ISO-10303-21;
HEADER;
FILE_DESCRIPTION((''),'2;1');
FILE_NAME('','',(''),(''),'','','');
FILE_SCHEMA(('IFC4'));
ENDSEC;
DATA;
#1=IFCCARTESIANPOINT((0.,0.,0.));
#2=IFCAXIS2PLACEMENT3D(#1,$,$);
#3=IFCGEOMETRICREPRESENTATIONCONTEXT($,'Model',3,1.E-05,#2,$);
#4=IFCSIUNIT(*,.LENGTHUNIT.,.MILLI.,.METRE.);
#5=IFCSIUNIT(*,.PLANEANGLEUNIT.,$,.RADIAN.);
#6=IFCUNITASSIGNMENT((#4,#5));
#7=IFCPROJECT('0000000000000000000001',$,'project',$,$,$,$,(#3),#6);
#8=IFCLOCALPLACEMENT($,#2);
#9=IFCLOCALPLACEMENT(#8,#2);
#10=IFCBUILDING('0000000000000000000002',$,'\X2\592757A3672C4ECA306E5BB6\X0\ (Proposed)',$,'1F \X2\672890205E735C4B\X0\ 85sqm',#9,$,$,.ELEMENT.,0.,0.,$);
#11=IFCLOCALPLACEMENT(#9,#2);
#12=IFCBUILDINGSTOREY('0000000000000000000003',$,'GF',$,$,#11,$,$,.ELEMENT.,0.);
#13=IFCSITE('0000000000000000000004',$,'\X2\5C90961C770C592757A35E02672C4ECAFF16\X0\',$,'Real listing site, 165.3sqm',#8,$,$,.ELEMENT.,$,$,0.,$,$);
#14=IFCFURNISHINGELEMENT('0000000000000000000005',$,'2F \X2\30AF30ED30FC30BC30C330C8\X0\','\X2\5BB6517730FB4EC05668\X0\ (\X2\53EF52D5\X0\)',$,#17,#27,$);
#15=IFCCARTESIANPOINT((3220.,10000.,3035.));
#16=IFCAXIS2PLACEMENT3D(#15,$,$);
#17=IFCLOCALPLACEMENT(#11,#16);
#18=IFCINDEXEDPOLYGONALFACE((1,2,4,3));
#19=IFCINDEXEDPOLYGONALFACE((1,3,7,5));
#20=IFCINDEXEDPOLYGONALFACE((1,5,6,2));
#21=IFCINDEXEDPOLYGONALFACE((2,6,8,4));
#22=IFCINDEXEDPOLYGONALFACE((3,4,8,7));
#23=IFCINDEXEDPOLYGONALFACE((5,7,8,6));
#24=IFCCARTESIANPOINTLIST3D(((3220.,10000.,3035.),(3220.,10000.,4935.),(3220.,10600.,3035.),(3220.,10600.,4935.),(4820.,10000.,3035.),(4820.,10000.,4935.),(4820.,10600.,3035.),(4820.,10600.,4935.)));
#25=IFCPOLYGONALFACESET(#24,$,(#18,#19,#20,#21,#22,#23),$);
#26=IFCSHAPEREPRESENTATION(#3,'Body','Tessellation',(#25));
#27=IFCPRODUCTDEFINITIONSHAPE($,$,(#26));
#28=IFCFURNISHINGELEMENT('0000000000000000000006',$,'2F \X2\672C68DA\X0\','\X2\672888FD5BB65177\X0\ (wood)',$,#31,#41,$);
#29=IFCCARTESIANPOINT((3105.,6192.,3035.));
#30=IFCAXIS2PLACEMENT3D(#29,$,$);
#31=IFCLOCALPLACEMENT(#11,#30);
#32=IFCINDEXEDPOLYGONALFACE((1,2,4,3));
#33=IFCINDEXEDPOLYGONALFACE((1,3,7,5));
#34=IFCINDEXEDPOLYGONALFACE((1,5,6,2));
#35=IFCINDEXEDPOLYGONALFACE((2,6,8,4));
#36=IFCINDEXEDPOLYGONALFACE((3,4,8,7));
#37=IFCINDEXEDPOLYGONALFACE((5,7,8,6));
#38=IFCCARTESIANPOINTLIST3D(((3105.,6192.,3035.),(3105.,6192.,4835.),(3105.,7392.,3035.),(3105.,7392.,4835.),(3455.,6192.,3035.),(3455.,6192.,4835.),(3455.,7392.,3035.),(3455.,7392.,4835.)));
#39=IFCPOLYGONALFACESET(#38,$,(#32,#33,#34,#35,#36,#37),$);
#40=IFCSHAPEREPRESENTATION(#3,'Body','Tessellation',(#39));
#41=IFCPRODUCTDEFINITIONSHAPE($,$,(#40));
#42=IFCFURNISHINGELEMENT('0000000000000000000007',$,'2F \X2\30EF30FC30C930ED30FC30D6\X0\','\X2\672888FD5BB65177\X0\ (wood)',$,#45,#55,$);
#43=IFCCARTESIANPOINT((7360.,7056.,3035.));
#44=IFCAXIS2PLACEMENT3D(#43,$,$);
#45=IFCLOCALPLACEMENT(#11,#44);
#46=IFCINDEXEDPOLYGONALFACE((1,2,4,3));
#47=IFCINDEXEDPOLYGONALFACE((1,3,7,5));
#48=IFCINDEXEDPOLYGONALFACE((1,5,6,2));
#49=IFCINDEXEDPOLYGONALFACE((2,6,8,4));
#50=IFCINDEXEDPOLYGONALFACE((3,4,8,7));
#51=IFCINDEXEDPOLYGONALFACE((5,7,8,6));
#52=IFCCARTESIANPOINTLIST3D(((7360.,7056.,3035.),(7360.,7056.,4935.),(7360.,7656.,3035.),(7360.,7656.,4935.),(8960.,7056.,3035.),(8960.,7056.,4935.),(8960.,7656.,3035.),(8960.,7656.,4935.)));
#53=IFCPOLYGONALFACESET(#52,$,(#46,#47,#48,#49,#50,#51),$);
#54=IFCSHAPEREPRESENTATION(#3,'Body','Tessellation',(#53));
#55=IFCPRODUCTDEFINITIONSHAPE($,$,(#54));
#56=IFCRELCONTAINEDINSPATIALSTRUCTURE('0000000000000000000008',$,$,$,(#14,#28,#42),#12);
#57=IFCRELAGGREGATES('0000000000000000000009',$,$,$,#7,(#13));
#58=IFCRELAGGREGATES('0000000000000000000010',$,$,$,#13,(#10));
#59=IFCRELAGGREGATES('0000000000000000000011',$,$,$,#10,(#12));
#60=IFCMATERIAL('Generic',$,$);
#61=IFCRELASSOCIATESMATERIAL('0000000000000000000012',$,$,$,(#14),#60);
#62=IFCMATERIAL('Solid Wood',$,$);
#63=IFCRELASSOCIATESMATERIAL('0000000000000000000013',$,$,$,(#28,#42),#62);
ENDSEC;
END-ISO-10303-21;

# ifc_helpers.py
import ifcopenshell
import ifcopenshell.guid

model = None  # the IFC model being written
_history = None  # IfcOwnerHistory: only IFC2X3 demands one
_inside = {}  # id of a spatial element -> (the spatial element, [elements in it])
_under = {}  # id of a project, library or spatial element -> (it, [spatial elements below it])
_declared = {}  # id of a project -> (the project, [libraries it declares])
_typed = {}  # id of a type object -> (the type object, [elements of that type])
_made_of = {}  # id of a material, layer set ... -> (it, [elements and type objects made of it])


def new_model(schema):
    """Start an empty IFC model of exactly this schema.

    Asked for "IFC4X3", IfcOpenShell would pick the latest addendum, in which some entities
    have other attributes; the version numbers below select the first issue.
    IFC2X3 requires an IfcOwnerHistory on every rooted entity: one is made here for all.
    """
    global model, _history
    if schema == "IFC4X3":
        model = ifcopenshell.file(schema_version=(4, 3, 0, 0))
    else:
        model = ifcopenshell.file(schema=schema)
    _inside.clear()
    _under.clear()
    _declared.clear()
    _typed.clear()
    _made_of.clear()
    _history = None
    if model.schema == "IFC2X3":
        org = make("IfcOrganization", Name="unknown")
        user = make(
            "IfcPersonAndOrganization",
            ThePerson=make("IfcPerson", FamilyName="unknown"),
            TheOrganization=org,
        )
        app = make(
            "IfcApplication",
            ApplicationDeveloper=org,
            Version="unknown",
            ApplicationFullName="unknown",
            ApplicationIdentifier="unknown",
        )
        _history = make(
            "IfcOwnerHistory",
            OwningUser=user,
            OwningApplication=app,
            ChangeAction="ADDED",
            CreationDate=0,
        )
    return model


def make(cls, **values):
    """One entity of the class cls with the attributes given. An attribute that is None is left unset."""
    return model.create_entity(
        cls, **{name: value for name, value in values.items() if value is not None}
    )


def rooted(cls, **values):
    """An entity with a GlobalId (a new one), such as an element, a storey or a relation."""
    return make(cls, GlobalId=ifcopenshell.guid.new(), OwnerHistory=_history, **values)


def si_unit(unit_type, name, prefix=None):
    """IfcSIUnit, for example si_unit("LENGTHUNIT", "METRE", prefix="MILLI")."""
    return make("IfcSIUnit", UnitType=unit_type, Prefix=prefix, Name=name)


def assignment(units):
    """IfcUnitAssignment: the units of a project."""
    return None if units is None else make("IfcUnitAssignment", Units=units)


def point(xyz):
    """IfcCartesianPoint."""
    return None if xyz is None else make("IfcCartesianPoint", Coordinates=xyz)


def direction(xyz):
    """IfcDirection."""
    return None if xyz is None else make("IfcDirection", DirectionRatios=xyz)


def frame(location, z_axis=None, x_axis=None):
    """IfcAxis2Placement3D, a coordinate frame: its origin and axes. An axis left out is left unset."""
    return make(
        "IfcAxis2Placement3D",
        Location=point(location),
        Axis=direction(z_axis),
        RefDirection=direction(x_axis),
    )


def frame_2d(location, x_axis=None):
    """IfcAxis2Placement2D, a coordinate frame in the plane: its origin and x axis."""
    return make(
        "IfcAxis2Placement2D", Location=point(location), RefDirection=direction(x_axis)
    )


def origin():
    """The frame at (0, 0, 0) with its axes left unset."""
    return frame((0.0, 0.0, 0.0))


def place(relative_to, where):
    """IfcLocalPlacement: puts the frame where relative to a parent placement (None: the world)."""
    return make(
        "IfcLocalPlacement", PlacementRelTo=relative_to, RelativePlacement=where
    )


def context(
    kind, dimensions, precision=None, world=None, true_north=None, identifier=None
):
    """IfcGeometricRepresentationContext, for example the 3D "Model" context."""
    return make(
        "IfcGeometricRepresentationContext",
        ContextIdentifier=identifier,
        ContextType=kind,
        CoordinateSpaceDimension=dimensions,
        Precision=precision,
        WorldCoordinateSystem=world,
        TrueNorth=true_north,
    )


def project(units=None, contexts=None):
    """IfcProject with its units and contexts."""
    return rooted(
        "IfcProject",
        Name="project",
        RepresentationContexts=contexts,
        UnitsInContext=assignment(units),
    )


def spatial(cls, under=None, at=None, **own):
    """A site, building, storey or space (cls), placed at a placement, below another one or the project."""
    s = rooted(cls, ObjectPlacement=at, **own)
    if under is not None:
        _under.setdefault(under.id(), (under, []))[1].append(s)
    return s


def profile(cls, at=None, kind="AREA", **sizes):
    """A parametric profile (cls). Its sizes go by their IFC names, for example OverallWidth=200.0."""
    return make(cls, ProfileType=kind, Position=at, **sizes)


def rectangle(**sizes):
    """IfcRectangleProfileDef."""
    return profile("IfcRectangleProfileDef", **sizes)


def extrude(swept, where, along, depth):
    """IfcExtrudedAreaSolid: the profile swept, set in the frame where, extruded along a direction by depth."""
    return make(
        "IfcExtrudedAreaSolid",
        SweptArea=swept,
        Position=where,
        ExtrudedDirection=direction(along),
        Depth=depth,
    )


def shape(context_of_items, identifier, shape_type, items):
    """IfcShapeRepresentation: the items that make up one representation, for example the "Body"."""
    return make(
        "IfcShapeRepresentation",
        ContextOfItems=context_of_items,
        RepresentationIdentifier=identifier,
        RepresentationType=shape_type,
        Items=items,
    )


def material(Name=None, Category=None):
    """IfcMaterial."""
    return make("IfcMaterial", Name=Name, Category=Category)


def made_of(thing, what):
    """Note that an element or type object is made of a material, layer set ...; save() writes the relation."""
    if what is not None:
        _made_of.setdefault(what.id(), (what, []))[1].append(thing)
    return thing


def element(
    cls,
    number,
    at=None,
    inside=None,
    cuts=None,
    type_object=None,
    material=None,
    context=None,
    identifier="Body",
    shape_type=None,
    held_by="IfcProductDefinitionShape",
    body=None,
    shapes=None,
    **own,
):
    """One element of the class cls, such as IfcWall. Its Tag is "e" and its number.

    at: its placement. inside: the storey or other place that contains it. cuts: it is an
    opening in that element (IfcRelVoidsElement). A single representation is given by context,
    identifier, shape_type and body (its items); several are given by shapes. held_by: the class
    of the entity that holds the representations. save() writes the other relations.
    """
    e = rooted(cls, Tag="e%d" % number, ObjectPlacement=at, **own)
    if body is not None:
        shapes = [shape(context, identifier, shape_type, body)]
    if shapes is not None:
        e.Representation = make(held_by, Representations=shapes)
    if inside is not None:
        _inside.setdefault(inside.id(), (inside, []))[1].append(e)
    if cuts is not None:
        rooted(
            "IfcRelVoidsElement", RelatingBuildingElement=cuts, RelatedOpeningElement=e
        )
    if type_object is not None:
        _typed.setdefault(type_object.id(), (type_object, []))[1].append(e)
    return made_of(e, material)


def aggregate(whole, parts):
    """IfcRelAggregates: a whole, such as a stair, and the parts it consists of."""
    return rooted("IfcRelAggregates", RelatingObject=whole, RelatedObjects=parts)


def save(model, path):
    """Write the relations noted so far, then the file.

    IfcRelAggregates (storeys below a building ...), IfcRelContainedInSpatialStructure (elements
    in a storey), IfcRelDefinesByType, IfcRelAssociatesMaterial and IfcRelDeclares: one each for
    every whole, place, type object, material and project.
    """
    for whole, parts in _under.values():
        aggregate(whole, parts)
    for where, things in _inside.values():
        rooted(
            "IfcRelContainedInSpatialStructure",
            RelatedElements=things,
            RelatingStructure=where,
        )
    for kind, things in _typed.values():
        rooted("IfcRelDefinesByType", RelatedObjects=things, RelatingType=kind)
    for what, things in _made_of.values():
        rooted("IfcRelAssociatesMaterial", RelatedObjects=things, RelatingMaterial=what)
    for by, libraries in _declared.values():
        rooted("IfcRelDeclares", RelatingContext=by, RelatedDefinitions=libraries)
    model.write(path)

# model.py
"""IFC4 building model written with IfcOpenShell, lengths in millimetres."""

from ifc_helpers import new_model, si_unit, frame, frame_2d, origin, place, context, project, spatial, rectangle, extrude, material, element, save


model = new_model("IFC4")

# Units and contexts
model_context = context("Model", 3, precision=1e-05, world=origin())
ifc_project = project(units=[si_unit("LENGTHUNIT", "METRE", prefix="MILLI"), si_unit("PLANEANGLEUNIT", "RADIAN")], contexts=[model_context])

# Site, building, storey
site_placement = place(None, origin())
site = spatial("IfcSite", under=ifc_project, at=site_placement, Name="岐阜県大垣市本今６", ObjectType="Real listing site, 165.3sqm", CompositionType="ELEMENT", RefElevation=0.0)
building_placement = place(site_placement, origin())
building = spatial("IfcBuilding", under=site, at=building_placement, Name="大垣本今の家 (Proposed)", ObjectType="1F 木造平屋 85sqm", CompositionType="ELEMENT", ElevationOfRefHeight=0.0, ElevationOfTerrain=0.0)
storey_placement = place(building_placement, origin())
storey = spatial("IfcBuildingStorey", under=building, at=storey_placement, Name="GF", CompositionType="ELEMENT", Elevation=0.0)

# Shared definitions
ifc_material_1 = material(Name="Solid Wood")

# Shared definitions
ifc_material_2 = material(Name="Generic")

# Furnishing elements
furnishing_1_placement = place(storey_placement, frame((3220.0, 10000.0, 3035.0)))
element("IfcFurnishingElement", 1, at=furnishing_1_placement, inside=storey, material=ifc_material_2, Name="2F クローゼット", Description="家具・什器 (可動)", context=model_context, shape_type="SweptSolid", body=[
    extrude(rectangle(XDim=1600.0, YDim=600.0, at=frame_2d((800.0, 300.0))), frame((3220.0, 10000.0, 3035.0)), (0.0, 0.0, 1.0), 1900.0),
])
furnishing_2_placement = place(storey_placement, frame((3105.0, 6192.0, 3035.0)))
element("IfcFurnishingElement", 2, at=furnishing_2_placement, inside=storey, material=ifc_material_1, Name="2F 本棚", Description="木製家具 (wood)", context=model_context, shape_type="SweptSolid", body=[
    extrude(rectangle(XDim=350.0, YDim=1200.0, at=frame_2d((175.0, 600.0))), frame((3105.0, 6192.0, 3035.0)), (0.0, 0.0, 1.0), 1800.0),
])
furnishing_3_placement = place(storey_placement, frame((7360.0, 7056.0, 3035.0)))
element("IfcFurnishingElement", 3, at=furnishing_3_placement, inside=storey, material=ifc_material_1, Name="2F ワードローブ", Description="木製家具 (wood)", context=model_context, shape_type="SweptSolid", body=[
    extrude(rectangle(XDim=1600.0, YDim=600.0, at=frame_2d((800.0, 300.0))), frame((7360.0, 7056.0, 3035.0)), (0.0, 0.0, 1.0), 1900.0),
])

save(model, "model.ifc")
